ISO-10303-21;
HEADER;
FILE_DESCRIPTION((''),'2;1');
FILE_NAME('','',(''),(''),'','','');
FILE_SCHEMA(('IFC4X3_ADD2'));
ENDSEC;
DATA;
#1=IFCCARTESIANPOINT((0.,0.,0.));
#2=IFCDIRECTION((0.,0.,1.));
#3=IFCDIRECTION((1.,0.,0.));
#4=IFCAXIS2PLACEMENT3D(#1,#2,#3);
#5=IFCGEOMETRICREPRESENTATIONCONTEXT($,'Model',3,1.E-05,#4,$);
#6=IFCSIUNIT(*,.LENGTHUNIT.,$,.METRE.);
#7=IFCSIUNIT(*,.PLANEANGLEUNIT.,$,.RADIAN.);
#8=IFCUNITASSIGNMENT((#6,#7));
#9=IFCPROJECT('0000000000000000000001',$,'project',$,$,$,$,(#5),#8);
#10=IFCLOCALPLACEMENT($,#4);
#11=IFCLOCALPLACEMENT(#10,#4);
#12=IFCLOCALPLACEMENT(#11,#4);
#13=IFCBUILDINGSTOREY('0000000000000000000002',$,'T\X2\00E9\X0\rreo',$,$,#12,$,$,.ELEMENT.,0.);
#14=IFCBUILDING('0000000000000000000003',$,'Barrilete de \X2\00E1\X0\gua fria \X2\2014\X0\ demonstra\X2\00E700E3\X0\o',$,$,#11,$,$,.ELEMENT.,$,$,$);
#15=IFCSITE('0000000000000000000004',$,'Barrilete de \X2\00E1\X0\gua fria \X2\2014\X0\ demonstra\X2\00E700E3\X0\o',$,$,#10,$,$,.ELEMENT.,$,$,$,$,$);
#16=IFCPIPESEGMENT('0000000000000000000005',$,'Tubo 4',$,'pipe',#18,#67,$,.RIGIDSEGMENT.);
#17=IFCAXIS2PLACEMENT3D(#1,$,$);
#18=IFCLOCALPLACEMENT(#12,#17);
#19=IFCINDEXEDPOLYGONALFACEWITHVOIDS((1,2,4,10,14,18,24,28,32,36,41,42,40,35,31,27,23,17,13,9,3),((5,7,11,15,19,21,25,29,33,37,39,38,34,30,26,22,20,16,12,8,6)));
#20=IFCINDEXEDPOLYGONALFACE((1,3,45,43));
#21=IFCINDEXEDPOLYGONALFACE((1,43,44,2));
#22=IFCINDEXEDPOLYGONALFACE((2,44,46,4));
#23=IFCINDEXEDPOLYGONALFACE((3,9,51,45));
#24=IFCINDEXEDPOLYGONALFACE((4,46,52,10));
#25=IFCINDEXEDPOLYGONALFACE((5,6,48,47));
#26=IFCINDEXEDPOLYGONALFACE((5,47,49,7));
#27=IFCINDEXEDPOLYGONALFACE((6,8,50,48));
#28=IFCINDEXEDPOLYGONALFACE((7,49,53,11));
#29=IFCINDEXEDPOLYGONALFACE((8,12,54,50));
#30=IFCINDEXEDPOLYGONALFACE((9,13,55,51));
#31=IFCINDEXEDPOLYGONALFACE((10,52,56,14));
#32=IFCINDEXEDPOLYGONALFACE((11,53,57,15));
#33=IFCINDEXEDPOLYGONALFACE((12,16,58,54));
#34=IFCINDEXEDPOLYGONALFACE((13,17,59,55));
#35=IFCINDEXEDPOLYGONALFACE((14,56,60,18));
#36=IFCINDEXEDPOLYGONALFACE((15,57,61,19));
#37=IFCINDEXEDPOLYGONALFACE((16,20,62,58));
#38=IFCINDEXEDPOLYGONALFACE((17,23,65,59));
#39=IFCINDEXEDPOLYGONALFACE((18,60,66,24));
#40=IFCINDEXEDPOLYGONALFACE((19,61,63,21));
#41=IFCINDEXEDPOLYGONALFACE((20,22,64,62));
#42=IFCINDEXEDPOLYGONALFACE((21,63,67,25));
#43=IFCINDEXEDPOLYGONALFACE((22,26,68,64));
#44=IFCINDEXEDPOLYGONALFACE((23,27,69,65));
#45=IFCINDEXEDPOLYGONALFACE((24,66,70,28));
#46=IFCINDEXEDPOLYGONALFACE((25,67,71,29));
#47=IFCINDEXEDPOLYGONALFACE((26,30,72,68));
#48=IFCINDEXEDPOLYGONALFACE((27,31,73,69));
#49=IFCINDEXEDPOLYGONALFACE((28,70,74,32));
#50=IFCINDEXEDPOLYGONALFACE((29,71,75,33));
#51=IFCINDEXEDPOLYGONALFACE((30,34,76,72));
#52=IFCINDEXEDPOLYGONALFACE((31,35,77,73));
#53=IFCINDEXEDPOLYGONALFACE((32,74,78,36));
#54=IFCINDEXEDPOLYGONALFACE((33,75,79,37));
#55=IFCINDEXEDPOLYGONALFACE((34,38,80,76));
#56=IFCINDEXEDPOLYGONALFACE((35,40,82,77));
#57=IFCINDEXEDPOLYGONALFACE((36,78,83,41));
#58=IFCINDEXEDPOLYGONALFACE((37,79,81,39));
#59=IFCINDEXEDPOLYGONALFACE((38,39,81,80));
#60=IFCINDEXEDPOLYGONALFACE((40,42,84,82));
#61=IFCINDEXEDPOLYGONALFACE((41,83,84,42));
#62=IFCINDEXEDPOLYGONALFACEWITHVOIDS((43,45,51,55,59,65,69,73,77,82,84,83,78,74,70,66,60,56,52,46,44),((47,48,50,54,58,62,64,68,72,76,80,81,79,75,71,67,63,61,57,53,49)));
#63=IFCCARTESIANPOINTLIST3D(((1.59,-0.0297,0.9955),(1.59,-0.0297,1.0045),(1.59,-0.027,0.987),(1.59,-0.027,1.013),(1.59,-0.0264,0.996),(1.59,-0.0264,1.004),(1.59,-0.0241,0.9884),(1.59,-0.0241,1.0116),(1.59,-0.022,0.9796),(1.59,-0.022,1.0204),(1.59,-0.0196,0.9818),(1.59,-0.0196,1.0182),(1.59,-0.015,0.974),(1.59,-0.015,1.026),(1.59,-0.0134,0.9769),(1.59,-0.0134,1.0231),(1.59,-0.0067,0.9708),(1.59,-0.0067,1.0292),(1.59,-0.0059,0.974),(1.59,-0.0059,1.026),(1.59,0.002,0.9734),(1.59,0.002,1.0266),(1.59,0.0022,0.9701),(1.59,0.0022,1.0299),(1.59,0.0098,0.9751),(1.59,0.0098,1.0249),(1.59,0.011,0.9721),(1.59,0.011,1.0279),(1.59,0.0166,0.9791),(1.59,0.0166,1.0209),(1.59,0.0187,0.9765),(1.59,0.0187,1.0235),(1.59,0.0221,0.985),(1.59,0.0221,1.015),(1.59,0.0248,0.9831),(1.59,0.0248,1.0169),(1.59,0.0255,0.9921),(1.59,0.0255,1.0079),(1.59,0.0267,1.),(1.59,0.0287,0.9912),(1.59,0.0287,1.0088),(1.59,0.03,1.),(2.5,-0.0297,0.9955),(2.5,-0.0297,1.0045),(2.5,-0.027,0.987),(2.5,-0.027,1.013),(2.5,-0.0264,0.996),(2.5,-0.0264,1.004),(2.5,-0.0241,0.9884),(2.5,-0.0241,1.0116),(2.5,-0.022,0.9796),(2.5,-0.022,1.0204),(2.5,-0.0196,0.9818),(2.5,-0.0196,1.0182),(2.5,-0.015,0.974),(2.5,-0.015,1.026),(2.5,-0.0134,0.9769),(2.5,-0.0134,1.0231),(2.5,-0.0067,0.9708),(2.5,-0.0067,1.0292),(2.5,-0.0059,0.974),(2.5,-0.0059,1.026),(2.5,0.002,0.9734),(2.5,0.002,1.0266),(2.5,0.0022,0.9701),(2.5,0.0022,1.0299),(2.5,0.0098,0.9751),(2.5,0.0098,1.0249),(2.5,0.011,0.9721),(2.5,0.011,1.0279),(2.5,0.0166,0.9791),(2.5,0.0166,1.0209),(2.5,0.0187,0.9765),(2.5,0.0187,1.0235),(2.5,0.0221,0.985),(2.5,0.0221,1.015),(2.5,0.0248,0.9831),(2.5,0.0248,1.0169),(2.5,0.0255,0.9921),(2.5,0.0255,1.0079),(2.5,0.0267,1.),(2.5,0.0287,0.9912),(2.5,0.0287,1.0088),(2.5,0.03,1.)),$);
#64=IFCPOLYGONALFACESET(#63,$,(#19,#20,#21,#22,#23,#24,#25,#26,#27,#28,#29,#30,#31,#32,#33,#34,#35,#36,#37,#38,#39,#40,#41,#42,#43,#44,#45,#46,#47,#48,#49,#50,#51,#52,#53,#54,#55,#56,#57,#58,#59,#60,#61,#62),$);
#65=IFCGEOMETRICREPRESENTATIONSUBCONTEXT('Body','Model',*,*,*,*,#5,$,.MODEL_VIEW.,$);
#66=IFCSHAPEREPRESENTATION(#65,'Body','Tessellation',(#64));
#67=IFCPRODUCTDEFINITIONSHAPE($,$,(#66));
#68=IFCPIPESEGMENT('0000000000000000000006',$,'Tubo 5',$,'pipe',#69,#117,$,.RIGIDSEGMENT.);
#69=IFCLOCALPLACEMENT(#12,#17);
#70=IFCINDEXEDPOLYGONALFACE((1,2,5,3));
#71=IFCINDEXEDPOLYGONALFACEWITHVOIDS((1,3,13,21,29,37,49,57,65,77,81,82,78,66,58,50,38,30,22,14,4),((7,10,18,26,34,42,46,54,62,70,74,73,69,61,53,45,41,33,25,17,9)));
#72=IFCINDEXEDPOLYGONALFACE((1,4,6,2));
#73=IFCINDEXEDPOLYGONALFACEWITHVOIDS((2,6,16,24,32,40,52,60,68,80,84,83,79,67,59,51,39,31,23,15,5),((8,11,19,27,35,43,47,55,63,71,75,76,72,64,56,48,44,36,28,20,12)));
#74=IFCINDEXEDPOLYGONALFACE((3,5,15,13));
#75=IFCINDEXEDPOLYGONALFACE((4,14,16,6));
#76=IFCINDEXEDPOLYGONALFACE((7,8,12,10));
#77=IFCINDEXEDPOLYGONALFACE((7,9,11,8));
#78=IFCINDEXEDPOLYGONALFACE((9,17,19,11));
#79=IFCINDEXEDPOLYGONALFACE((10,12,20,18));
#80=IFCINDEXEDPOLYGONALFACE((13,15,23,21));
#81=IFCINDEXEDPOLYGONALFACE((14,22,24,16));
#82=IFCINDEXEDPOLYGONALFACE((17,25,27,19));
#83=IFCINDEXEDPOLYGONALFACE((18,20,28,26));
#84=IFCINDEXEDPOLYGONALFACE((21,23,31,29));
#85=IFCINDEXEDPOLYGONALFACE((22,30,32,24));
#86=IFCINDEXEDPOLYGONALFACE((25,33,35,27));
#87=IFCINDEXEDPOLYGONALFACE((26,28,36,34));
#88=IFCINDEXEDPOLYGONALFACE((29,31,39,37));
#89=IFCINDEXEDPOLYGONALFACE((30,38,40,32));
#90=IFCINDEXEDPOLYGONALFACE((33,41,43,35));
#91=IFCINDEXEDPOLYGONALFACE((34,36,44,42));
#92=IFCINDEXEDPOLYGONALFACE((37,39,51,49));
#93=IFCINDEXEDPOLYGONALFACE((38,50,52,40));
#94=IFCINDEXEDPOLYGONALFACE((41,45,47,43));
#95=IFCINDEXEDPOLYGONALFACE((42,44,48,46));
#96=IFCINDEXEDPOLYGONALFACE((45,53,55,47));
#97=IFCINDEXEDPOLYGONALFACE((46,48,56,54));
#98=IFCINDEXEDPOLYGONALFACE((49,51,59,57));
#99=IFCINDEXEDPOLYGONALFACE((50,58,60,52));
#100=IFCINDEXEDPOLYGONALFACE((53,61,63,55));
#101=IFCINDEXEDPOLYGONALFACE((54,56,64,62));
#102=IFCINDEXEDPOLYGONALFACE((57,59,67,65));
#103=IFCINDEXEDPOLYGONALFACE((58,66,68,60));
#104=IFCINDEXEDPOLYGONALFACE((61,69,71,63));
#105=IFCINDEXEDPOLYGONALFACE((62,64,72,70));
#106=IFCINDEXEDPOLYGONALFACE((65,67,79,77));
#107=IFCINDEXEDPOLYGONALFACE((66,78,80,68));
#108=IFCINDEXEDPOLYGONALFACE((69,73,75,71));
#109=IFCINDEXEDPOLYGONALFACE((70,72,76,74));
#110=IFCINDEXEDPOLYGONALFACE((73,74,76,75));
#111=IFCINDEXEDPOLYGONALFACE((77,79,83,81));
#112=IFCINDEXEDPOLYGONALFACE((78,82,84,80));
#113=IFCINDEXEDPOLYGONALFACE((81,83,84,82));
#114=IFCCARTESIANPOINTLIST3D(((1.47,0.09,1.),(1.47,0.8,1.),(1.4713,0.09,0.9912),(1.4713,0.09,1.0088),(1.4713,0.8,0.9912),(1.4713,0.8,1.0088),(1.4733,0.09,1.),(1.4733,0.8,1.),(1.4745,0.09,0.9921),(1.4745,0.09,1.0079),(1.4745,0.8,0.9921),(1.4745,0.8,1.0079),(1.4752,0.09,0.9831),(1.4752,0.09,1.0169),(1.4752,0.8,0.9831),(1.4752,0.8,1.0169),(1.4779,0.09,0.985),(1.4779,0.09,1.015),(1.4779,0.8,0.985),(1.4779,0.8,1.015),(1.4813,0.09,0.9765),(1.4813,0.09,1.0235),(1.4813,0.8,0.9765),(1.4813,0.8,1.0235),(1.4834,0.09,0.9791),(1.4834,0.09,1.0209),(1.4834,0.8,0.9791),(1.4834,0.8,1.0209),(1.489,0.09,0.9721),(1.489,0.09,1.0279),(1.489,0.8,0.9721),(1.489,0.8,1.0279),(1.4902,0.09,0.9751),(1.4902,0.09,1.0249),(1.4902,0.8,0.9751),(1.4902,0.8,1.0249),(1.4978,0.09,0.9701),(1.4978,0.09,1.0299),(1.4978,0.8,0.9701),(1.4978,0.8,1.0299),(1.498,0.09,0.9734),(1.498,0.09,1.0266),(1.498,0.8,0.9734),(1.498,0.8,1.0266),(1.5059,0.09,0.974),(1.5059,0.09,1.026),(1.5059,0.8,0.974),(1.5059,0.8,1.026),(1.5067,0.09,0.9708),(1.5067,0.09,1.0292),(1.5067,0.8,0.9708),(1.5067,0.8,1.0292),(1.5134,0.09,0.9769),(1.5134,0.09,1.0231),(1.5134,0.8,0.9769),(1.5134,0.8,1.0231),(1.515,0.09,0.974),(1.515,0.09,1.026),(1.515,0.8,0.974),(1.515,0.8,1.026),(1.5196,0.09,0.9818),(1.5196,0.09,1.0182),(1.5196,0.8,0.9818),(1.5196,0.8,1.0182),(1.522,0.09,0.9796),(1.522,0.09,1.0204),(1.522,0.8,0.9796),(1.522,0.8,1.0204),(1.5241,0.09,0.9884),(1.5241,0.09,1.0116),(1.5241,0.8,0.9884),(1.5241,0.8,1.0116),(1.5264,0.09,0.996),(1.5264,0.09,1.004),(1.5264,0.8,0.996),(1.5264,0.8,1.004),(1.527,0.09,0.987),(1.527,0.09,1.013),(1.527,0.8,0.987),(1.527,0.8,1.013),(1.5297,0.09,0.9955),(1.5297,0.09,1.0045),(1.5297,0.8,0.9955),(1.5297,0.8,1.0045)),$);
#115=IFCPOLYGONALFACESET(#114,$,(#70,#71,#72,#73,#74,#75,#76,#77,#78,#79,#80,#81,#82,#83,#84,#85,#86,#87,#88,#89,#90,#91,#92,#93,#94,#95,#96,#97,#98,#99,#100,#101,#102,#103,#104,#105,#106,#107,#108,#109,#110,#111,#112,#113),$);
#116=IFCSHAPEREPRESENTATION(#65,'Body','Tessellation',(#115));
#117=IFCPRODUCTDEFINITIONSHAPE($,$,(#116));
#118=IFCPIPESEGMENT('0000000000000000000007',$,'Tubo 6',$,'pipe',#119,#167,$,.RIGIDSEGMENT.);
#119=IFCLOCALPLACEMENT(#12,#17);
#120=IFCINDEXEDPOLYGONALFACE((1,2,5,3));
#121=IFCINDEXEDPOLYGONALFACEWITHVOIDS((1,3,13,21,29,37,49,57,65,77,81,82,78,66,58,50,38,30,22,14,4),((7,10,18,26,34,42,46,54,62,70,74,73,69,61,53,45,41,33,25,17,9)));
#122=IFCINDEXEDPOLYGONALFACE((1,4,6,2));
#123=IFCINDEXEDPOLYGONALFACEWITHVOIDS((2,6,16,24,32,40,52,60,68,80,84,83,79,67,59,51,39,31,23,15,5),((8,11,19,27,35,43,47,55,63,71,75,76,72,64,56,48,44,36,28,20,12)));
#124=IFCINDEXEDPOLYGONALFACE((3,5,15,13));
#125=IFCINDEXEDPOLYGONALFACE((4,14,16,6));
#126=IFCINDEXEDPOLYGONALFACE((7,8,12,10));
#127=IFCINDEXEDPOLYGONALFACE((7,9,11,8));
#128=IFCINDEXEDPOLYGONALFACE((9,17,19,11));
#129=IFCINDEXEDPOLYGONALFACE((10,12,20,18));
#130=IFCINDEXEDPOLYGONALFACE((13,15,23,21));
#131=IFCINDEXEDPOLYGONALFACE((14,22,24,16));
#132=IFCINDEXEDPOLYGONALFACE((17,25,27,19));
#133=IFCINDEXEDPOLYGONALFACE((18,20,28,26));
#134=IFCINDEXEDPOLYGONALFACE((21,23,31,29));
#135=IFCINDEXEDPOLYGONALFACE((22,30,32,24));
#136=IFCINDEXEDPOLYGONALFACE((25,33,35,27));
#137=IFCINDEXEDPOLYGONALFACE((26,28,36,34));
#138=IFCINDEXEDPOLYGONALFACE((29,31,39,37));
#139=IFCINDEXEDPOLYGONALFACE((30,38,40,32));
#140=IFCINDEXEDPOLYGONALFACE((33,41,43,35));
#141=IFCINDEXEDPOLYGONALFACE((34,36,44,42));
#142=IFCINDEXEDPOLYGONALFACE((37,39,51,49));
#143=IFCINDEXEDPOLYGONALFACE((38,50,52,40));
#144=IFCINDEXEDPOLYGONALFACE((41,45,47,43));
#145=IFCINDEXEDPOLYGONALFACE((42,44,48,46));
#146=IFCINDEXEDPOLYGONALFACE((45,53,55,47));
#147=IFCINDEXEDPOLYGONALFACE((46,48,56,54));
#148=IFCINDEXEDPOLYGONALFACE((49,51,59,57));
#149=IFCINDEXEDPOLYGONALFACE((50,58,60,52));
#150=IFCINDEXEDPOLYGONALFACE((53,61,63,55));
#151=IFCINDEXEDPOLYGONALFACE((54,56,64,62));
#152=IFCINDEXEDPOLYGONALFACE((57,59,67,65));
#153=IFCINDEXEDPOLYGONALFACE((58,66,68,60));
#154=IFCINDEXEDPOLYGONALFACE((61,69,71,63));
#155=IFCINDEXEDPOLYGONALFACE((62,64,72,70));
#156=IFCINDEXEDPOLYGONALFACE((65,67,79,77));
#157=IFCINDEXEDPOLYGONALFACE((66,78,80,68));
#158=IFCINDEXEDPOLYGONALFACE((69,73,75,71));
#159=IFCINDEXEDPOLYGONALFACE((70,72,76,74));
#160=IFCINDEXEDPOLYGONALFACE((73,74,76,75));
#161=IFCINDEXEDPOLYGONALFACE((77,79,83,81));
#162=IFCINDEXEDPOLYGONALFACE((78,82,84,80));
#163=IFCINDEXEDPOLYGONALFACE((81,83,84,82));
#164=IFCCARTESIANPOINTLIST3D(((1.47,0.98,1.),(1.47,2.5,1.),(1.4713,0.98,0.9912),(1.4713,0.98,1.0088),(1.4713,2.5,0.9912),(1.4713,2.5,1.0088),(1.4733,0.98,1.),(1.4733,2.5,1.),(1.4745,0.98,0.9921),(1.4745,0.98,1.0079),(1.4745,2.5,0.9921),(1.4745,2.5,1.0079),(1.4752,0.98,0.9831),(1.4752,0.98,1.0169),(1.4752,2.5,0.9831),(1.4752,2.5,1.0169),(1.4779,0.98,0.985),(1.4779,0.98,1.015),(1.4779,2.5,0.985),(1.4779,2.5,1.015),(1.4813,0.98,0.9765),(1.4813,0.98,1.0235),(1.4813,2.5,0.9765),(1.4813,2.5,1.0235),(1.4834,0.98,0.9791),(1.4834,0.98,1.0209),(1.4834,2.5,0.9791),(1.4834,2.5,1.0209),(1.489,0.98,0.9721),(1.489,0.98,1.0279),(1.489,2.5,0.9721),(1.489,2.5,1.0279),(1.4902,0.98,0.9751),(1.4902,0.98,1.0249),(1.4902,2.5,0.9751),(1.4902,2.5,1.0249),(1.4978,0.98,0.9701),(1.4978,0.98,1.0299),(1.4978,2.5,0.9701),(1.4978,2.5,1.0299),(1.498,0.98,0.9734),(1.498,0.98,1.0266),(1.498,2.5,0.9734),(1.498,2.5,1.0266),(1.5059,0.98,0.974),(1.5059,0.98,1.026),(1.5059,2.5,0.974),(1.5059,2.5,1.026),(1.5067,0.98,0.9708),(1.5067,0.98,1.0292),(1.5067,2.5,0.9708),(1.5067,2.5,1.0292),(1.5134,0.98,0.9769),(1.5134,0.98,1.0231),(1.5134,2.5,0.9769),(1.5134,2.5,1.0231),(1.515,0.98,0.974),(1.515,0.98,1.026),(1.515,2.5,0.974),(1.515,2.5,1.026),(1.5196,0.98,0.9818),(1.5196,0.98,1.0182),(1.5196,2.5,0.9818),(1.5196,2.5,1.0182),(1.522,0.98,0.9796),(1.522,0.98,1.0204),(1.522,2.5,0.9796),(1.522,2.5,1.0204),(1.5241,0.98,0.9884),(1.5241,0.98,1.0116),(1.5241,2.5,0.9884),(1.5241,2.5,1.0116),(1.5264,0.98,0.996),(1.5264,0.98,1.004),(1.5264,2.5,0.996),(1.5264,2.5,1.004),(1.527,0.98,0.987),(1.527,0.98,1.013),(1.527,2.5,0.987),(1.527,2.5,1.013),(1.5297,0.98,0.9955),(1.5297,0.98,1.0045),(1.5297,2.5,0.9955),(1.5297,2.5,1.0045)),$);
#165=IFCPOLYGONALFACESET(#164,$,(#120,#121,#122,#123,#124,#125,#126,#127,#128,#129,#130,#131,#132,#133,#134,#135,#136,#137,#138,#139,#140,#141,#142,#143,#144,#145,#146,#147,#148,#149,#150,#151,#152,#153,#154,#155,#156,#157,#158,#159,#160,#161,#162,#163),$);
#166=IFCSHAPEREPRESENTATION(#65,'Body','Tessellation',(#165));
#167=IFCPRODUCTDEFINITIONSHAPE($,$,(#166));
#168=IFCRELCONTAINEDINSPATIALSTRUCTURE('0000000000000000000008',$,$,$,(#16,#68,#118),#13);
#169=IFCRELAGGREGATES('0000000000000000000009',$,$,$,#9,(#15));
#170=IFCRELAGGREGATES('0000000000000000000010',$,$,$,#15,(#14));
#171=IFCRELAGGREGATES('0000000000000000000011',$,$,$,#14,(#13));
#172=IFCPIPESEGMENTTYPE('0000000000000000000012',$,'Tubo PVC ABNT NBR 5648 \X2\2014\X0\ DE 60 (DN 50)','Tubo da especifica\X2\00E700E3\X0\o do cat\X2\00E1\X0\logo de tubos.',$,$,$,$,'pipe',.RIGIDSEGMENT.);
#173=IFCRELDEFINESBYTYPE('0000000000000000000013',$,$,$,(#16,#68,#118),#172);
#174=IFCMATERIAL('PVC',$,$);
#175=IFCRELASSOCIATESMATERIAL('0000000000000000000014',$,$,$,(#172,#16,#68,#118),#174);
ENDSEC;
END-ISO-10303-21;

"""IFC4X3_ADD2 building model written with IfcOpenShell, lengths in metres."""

from ifc_helpers import new_model, si_unit, frame, origin_with_axes, place, context, subcontext, project, spatial, hollow_circle, extrude, material, type_object, element, save


model = new_model("IFC4X3_ADD2")

# Units and contexts
model_context = context("Model", 3, precision=1e-05, world=origin_with_axes())
body_context = subcontext(model_context, "Body", "Model", "MODEL_VIEW")
ifc_project = project(units=[si_unit("LENGTHUNIT", "METRE"), si_unit("PLANEANGLEUNIT", "RADIAN")], contexts=[model_context])

# Site, building, storey
site_placement = place(None, origin_with_axes())
site = spatial("IfcSite", under=ifc_project, at=site_placement, Name="Barrilete de água fria — demonstração", CompositionType="ELEMENT")
building_placement = place(site_placement, origin_with_axes())
building = spatial("IfcBuilding", under=site, at=building_placement, Name="Barrilete de água fria — demonstração", CompositionType="ELEMENT")
storey_placement = place(building_placement, origin_with_axes())
storey = spatial("IfcBuildingStorey", under=building, at=storey_placement, Name="Térreo", CompositionType="ELEMENT", Elevation=0.0)

# Pipe segments
ifc_material = material(Name="PVC")
pipe_segment_type_1 = type_object("IfcPipeSegmentType", Name="Tubo PVC ABNT NBR 5648 — DE 60 (DN 50)", Description="Tubo da especificação do catálogo de tubos.", ElementType="pipe", PredefinedType="RIGIDSEGMENT", material=ifc_material)
pipe_segment_1_placement = place(storey_placement, frame((1.59, 0.0, 1.0), z_axis=(0.0, 0.0, 1.0), x_axis=(1.0, 0.0, 0.0)))
element("IfcPipeSegment", 1, at=pipe_segment_1_placement, inside=storey, type_object=pipe_segment_type_1, material=ifc_material, Name="Tubo 4", ObjectType="pipe", PredefinedType="RIGIDSEGMENT", context=body_context, shape_type="SweptSolid", body=[
    extrude(hollow_circle(Radius=0.03, WallThickness=0.0033), frame((0.0, 0.0, 0.0), z_axis=(1.0, 0.0, 0.0), x_axis=(0.0, 1.0, 0.0)), (0.0, 0.0, 1.0), 0.91),
])
pipe_segment_2_placement = place(storey_placement, frame((1.5, 0.09, 1.0), z_axis=(0.0, 0.0, 1.0), x_axis=(0.0, 1.0, 0.0)))
element("IfcPipeSegment", 2, at=pipe_segment_2_placement, inside=storey, type_object=pipe_segment_type_1, material=ifc_material, Name="Tubo 5", ObjectType="pipe", PredefinedType="RIGIDSEGMENT", context=body_context, shape_type="SweptSolid", body=[
    extrude(hollow_circle(Radius=0.03, WallThickness=0.0033), frame((0.0, 0.0, 0.0), z_axis=(1.0, 0.0, 0.0), x_axis=(0.0, 1.0, 0.0)), (0.0, 0.0, 1.0), 0.71),
])
pipe_segment_3_placement = place(storey_placement, frame((1.5, 0.98, 1.0), z_axis=(0.0, 0.0, 1.0), x_axis=(0.0, 1.0, 0.0)))
element("IfcPipeSegment", 3, at=pipe_segment_3_placement, inside=storey, type_object=pipe_segment_type_1, material=ifc_material, Name="Tubo 6", ObjectType="pipe", PredefinedType="RIGIDSEGMENT", context=body_context, shape_type="SweptSolid", body=[
    extrude(hollow_circle(Radius=0.03, WallThickness=0.0033), frame((0.0, 0.0, 0.0), z_axis=(1.0, 0.0, 0.0), x_axis=(0.0, 1.0, 0.0)), (0.0, 0.0, 1.0), 1.52),
])

save(model, "model.ifc")
